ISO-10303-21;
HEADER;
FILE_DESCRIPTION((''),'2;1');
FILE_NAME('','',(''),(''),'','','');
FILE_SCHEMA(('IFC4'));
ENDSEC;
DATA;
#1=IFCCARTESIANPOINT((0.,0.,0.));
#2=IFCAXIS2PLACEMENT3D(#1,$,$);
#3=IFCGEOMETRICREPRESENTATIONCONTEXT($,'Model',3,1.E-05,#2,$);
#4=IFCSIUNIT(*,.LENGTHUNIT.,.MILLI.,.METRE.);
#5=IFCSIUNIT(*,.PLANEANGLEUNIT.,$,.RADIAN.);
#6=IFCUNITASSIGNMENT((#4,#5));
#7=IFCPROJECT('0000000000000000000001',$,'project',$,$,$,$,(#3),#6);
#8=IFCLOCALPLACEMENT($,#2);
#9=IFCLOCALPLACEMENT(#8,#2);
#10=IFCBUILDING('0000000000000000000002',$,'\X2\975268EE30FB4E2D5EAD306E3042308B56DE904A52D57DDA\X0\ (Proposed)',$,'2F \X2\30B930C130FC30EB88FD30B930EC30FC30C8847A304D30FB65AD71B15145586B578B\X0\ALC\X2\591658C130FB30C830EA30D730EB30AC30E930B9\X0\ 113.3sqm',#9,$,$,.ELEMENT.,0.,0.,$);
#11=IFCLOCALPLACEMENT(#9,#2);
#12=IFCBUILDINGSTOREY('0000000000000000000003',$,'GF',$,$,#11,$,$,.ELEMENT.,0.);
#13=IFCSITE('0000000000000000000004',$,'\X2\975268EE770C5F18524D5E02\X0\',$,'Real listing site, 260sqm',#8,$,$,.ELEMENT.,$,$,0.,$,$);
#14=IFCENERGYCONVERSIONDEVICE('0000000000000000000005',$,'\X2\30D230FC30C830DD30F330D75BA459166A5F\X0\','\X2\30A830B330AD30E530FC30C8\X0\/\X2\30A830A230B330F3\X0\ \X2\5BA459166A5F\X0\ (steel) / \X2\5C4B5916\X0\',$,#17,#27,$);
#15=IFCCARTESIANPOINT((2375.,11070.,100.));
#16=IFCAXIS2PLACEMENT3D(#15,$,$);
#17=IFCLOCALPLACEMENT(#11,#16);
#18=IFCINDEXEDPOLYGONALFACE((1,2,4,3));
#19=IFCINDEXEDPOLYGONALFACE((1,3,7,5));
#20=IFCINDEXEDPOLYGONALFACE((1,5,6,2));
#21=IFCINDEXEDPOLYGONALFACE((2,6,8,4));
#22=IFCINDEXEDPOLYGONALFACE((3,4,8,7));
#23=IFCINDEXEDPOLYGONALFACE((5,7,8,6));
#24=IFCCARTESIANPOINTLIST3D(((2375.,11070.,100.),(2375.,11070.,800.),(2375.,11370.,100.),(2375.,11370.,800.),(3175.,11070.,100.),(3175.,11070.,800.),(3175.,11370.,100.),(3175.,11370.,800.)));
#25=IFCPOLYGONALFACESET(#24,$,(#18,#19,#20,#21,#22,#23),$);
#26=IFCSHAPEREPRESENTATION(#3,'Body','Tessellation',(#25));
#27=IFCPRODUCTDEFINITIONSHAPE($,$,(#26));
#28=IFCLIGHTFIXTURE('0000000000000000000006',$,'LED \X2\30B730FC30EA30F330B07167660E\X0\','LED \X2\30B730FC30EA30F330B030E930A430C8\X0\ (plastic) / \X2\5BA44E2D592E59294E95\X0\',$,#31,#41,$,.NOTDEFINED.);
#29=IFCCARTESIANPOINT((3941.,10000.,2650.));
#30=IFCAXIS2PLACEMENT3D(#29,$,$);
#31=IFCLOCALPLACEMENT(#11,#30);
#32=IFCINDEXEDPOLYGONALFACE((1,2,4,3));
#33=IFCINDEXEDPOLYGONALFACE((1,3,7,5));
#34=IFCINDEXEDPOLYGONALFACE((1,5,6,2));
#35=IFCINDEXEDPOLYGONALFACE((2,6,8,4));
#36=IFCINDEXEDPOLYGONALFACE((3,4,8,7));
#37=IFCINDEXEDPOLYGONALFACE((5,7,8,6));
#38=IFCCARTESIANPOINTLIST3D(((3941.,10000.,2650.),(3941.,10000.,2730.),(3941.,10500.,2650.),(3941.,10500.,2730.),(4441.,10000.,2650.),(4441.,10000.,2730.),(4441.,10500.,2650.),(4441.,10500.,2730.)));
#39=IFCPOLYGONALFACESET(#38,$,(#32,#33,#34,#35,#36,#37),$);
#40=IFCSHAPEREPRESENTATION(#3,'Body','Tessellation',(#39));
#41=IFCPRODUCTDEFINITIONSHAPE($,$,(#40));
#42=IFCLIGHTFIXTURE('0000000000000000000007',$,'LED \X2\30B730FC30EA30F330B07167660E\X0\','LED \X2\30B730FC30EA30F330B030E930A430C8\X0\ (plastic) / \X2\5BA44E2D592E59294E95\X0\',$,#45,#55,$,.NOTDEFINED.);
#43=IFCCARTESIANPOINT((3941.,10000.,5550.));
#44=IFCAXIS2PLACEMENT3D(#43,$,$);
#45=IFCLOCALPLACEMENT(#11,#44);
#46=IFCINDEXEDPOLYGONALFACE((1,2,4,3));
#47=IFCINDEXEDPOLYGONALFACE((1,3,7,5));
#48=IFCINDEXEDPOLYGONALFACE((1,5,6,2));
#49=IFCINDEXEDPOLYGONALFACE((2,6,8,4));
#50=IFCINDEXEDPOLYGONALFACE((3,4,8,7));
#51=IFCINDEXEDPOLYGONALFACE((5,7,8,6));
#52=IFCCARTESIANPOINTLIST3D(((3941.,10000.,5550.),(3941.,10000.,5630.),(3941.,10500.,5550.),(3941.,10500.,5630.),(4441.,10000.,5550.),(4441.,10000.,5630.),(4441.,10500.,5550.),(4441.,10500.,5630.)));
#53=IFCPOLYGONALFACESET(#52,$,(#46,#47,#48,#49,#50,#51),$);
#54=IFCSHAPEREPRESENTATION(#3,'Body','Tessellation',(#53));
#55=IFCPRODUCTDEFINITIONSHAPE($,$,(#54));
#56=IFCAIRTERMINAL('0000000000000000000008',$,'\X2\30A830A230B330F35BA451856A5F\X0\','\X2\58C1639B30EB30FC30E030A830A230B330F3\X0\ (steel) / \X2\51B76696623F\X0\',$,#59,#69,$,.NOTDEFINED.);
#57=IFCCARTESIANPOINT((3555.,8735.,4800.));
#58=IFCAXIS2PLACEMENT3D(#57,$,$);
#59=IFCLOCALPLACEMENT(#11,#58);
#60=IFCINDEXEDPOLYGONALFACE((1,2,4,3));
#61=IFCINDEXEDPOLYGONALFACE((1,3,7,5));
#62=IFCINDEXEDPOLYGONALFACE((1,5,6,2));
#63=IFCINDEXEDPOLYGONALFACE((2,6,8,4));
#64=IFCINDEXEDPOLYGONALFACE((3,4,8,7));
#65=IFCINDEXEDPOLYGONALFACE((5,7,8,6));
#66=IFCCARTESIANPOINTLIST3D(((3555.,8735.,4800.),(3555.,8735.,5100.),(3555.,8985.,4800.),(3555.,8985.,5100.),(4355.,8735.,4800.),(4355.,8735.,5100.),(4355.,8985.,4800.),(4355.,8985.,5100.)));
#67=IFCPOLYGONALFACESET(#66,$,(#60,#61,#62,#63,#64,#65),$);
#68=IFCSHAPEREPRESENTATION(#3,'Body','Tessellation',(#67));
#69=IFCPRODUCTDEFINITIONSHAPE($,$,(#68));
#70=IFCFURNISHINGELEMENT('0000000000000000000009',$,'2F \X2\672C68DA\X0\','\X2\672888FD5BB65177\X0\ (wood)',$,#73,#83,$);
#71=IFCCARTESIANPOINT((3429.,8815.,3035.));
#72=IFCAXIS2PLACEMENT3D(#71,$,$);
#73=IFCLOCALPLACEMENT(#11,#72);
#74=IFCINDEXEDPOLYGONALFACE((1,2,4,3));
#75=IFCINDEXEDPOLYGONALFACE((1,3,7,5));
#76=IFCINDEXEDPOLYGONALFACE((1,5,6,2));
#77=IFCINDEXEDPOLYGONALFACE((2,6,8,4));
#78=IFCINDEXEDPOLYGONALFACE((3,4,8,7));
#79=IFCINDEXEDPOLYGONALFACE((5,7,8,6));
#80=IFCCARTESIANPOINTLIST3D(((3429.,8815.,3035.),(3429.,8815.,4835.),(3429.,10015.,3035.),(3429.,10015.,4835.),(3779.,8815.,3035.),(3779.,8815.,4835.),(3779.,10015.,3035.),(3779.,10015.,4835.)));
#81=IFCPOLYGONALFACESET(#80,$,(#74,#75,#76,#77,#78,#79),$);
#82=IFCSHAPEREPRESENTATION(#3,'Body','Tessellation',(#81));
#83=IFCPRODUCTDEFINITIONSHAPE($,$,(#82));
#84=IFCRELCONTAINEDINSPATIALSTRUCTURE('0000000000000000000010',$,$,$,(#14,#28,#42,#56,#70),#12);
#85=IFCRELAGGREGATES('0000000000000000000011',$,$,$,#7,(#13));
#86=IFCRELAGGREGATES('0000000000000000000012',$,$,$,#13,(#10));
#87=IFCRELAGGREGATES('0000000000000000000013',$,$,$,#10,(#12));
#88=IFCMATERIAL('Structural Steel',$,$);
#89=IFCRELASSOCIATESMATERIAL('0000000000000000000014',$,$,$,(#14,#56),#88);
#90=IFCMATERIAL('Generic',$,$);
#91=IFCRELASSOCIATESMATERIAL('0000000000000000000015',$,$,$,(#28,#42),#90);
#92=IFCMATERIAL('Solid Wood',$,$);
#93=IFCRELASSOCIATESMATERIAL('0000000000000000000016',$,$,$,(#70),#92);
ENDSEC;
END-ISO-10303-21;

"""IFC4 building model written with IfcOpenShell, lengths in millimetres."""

from ifc_helpers import new_model, si_unit, frame, frame_2d, origin, place, context, project, spatial, rectangle, extrude, material, element, save


model = new_model("IFC4")

# Units and contexts
model_context = context("Model", 3, precision=1e-05, world=origin())
ifc_project = project(units=[si_unit("LENGTHUNIT", "METRE", prefix="MILLI"), si_unit("PLANEANGLEUNIT", "RADIAN")], contexts=[model_context])

# Site, building, storey
site_placement = place(None, origin())
site = spatial("IfcSite", under=ifc_project, at=site_placement, Name="青森県弘前市", ObjectType="Real listing site, 260sqm", CompositionType="ELEMENT", RefElevation=0.0)
building_placement = place(site_placement, origin())
building = spatial("IfcBuilding", under=site, at=building_placement, Name="青森・中庭のある回遊動線 (Proposed)", ObjectType="2F スチール製スレート葺き・断熱充填型ALC外壁・トリプルガラス 113.3sqm", CompositionType="ELEMENT", ElevationOfRefHeight=0.0, ElevationOfTerrain=0.0)
storey_placement = place(building_placement, origin())
storey = spatial("IfcBuildingStorey", under=building, at=storey_placement, Name="GF", CompositionType="ELEMENT", Elevation=0.0)

# Shared definitions
ifc_material_1 = material(Name="Solid Wood")

# Shared definitions
ifc_material_2 = material(Name="Structural Steel")

# Shared definitions
ifc_material_3 = material(Name="Generic")

# Energy conversion device
energy_conversion_device_placement = place(storey_placement, frame((2375.0, 11070.0, 100.0)))
element("IfcEnergyConversionDevice", 1, at=energy_conversion_device_placement, inside=storey, material=ifc_material_2, Name="ヒートポンプ室外機", Description="エコキュート/エアコン 室外機 (steel) / 屋外", context=model_context, shape_type="SweptSolid", body=[
    extrude(rectangle(XDim=800.0, YDim=300.0, at=frame_2d((400.0, 150.0))), frame((2375.0, 11070.0, 100.0)), (0.0, 0.0, 1.0), 700.0),
])

# Light fixtures
light_fixture_1_placement = place(storey_placement, frame((3941.0, 10000.0, 2650.0)))
element("IfcLightFixture", 2, at=light_fixture_1_placement, inside=storey, material=ifc_material_3, Name="LED シーリング照明", Description="LED シーリングライト (plastic) / 室中央天井", PredefinedType="NOTDEFINED", context=model_context, shape_type="SweptSolid", body=[
    extrude(rectangle(XDim=500.0, YDim=500.0, at=frame_2d((250.0, 250.0))), frame((3941.0, 10000.0, 2650.0)), (0.0, 0.0, 1.0), 80.0),
])
light_fixture_2_placement = place(storey_placement, frame((3941.0, 10000.0, 5550.0)))
element("IfcLightFixture", 3, at=light_fixture_2_placement, inside=storey, material=ifc_material_3, Name="LED シーリング照明", Description="LED シーリングライト (plastic) / 室中央天井", PredefinedType="NOTDEFINED", context=model_context, shape_type="SweptSolid", body=[
    extrude(rectangle(XDim=500.0, YDim=500.0, at=frame_2d((250.0, 250.0))), frame((3941.0, 10000.0, 5550.0)), (0.0, 0.0, 1.0), 80.0),
])

# Air terminal
air_terminal_placement = place(storey_placement, frame((3555.0, 8735.0, 4800.0)))
element("IfcAirTerminal", 4, at=air_terminal_placement, inside=storey, material=ifc_material_2, Name="エアコン室内機", Description="壁掛ルームエアコン (steel) / 冷暖房", PredefinedType="NOTDEFINED", context=model_context, shape_type="SweptSolid", body=[
    extrude(rectangle(XDim=800.0, YDim=250.0, at=frame_2d((400.0, 125.0))), frame((3555.0, 8735.0, 4800.0)), (0.0, 0.0, 1.0), 300.0),
])

# Furnishing element
furnishing_placement = place(storey_placement, frame((3429.0, 8815.0, 3035.0)))
element("IfcFurnishingElement", 5, at=furnishing_placement, inside=storey, material=ifc_material_1, Name="2F 本棚", Description="木製家具 (wood)", context=model_context, shape_type="SweptSolid", body=[
    extrude(rectangle(XDim=350.0, YDim=1200.0, at=frame_2d((175.0, 600.0))), frame((3429.0, 8815.0, 3035.0)), (0.0, 0.0, 1.0), 1800.0),
])

save(model, "model.ifc")
